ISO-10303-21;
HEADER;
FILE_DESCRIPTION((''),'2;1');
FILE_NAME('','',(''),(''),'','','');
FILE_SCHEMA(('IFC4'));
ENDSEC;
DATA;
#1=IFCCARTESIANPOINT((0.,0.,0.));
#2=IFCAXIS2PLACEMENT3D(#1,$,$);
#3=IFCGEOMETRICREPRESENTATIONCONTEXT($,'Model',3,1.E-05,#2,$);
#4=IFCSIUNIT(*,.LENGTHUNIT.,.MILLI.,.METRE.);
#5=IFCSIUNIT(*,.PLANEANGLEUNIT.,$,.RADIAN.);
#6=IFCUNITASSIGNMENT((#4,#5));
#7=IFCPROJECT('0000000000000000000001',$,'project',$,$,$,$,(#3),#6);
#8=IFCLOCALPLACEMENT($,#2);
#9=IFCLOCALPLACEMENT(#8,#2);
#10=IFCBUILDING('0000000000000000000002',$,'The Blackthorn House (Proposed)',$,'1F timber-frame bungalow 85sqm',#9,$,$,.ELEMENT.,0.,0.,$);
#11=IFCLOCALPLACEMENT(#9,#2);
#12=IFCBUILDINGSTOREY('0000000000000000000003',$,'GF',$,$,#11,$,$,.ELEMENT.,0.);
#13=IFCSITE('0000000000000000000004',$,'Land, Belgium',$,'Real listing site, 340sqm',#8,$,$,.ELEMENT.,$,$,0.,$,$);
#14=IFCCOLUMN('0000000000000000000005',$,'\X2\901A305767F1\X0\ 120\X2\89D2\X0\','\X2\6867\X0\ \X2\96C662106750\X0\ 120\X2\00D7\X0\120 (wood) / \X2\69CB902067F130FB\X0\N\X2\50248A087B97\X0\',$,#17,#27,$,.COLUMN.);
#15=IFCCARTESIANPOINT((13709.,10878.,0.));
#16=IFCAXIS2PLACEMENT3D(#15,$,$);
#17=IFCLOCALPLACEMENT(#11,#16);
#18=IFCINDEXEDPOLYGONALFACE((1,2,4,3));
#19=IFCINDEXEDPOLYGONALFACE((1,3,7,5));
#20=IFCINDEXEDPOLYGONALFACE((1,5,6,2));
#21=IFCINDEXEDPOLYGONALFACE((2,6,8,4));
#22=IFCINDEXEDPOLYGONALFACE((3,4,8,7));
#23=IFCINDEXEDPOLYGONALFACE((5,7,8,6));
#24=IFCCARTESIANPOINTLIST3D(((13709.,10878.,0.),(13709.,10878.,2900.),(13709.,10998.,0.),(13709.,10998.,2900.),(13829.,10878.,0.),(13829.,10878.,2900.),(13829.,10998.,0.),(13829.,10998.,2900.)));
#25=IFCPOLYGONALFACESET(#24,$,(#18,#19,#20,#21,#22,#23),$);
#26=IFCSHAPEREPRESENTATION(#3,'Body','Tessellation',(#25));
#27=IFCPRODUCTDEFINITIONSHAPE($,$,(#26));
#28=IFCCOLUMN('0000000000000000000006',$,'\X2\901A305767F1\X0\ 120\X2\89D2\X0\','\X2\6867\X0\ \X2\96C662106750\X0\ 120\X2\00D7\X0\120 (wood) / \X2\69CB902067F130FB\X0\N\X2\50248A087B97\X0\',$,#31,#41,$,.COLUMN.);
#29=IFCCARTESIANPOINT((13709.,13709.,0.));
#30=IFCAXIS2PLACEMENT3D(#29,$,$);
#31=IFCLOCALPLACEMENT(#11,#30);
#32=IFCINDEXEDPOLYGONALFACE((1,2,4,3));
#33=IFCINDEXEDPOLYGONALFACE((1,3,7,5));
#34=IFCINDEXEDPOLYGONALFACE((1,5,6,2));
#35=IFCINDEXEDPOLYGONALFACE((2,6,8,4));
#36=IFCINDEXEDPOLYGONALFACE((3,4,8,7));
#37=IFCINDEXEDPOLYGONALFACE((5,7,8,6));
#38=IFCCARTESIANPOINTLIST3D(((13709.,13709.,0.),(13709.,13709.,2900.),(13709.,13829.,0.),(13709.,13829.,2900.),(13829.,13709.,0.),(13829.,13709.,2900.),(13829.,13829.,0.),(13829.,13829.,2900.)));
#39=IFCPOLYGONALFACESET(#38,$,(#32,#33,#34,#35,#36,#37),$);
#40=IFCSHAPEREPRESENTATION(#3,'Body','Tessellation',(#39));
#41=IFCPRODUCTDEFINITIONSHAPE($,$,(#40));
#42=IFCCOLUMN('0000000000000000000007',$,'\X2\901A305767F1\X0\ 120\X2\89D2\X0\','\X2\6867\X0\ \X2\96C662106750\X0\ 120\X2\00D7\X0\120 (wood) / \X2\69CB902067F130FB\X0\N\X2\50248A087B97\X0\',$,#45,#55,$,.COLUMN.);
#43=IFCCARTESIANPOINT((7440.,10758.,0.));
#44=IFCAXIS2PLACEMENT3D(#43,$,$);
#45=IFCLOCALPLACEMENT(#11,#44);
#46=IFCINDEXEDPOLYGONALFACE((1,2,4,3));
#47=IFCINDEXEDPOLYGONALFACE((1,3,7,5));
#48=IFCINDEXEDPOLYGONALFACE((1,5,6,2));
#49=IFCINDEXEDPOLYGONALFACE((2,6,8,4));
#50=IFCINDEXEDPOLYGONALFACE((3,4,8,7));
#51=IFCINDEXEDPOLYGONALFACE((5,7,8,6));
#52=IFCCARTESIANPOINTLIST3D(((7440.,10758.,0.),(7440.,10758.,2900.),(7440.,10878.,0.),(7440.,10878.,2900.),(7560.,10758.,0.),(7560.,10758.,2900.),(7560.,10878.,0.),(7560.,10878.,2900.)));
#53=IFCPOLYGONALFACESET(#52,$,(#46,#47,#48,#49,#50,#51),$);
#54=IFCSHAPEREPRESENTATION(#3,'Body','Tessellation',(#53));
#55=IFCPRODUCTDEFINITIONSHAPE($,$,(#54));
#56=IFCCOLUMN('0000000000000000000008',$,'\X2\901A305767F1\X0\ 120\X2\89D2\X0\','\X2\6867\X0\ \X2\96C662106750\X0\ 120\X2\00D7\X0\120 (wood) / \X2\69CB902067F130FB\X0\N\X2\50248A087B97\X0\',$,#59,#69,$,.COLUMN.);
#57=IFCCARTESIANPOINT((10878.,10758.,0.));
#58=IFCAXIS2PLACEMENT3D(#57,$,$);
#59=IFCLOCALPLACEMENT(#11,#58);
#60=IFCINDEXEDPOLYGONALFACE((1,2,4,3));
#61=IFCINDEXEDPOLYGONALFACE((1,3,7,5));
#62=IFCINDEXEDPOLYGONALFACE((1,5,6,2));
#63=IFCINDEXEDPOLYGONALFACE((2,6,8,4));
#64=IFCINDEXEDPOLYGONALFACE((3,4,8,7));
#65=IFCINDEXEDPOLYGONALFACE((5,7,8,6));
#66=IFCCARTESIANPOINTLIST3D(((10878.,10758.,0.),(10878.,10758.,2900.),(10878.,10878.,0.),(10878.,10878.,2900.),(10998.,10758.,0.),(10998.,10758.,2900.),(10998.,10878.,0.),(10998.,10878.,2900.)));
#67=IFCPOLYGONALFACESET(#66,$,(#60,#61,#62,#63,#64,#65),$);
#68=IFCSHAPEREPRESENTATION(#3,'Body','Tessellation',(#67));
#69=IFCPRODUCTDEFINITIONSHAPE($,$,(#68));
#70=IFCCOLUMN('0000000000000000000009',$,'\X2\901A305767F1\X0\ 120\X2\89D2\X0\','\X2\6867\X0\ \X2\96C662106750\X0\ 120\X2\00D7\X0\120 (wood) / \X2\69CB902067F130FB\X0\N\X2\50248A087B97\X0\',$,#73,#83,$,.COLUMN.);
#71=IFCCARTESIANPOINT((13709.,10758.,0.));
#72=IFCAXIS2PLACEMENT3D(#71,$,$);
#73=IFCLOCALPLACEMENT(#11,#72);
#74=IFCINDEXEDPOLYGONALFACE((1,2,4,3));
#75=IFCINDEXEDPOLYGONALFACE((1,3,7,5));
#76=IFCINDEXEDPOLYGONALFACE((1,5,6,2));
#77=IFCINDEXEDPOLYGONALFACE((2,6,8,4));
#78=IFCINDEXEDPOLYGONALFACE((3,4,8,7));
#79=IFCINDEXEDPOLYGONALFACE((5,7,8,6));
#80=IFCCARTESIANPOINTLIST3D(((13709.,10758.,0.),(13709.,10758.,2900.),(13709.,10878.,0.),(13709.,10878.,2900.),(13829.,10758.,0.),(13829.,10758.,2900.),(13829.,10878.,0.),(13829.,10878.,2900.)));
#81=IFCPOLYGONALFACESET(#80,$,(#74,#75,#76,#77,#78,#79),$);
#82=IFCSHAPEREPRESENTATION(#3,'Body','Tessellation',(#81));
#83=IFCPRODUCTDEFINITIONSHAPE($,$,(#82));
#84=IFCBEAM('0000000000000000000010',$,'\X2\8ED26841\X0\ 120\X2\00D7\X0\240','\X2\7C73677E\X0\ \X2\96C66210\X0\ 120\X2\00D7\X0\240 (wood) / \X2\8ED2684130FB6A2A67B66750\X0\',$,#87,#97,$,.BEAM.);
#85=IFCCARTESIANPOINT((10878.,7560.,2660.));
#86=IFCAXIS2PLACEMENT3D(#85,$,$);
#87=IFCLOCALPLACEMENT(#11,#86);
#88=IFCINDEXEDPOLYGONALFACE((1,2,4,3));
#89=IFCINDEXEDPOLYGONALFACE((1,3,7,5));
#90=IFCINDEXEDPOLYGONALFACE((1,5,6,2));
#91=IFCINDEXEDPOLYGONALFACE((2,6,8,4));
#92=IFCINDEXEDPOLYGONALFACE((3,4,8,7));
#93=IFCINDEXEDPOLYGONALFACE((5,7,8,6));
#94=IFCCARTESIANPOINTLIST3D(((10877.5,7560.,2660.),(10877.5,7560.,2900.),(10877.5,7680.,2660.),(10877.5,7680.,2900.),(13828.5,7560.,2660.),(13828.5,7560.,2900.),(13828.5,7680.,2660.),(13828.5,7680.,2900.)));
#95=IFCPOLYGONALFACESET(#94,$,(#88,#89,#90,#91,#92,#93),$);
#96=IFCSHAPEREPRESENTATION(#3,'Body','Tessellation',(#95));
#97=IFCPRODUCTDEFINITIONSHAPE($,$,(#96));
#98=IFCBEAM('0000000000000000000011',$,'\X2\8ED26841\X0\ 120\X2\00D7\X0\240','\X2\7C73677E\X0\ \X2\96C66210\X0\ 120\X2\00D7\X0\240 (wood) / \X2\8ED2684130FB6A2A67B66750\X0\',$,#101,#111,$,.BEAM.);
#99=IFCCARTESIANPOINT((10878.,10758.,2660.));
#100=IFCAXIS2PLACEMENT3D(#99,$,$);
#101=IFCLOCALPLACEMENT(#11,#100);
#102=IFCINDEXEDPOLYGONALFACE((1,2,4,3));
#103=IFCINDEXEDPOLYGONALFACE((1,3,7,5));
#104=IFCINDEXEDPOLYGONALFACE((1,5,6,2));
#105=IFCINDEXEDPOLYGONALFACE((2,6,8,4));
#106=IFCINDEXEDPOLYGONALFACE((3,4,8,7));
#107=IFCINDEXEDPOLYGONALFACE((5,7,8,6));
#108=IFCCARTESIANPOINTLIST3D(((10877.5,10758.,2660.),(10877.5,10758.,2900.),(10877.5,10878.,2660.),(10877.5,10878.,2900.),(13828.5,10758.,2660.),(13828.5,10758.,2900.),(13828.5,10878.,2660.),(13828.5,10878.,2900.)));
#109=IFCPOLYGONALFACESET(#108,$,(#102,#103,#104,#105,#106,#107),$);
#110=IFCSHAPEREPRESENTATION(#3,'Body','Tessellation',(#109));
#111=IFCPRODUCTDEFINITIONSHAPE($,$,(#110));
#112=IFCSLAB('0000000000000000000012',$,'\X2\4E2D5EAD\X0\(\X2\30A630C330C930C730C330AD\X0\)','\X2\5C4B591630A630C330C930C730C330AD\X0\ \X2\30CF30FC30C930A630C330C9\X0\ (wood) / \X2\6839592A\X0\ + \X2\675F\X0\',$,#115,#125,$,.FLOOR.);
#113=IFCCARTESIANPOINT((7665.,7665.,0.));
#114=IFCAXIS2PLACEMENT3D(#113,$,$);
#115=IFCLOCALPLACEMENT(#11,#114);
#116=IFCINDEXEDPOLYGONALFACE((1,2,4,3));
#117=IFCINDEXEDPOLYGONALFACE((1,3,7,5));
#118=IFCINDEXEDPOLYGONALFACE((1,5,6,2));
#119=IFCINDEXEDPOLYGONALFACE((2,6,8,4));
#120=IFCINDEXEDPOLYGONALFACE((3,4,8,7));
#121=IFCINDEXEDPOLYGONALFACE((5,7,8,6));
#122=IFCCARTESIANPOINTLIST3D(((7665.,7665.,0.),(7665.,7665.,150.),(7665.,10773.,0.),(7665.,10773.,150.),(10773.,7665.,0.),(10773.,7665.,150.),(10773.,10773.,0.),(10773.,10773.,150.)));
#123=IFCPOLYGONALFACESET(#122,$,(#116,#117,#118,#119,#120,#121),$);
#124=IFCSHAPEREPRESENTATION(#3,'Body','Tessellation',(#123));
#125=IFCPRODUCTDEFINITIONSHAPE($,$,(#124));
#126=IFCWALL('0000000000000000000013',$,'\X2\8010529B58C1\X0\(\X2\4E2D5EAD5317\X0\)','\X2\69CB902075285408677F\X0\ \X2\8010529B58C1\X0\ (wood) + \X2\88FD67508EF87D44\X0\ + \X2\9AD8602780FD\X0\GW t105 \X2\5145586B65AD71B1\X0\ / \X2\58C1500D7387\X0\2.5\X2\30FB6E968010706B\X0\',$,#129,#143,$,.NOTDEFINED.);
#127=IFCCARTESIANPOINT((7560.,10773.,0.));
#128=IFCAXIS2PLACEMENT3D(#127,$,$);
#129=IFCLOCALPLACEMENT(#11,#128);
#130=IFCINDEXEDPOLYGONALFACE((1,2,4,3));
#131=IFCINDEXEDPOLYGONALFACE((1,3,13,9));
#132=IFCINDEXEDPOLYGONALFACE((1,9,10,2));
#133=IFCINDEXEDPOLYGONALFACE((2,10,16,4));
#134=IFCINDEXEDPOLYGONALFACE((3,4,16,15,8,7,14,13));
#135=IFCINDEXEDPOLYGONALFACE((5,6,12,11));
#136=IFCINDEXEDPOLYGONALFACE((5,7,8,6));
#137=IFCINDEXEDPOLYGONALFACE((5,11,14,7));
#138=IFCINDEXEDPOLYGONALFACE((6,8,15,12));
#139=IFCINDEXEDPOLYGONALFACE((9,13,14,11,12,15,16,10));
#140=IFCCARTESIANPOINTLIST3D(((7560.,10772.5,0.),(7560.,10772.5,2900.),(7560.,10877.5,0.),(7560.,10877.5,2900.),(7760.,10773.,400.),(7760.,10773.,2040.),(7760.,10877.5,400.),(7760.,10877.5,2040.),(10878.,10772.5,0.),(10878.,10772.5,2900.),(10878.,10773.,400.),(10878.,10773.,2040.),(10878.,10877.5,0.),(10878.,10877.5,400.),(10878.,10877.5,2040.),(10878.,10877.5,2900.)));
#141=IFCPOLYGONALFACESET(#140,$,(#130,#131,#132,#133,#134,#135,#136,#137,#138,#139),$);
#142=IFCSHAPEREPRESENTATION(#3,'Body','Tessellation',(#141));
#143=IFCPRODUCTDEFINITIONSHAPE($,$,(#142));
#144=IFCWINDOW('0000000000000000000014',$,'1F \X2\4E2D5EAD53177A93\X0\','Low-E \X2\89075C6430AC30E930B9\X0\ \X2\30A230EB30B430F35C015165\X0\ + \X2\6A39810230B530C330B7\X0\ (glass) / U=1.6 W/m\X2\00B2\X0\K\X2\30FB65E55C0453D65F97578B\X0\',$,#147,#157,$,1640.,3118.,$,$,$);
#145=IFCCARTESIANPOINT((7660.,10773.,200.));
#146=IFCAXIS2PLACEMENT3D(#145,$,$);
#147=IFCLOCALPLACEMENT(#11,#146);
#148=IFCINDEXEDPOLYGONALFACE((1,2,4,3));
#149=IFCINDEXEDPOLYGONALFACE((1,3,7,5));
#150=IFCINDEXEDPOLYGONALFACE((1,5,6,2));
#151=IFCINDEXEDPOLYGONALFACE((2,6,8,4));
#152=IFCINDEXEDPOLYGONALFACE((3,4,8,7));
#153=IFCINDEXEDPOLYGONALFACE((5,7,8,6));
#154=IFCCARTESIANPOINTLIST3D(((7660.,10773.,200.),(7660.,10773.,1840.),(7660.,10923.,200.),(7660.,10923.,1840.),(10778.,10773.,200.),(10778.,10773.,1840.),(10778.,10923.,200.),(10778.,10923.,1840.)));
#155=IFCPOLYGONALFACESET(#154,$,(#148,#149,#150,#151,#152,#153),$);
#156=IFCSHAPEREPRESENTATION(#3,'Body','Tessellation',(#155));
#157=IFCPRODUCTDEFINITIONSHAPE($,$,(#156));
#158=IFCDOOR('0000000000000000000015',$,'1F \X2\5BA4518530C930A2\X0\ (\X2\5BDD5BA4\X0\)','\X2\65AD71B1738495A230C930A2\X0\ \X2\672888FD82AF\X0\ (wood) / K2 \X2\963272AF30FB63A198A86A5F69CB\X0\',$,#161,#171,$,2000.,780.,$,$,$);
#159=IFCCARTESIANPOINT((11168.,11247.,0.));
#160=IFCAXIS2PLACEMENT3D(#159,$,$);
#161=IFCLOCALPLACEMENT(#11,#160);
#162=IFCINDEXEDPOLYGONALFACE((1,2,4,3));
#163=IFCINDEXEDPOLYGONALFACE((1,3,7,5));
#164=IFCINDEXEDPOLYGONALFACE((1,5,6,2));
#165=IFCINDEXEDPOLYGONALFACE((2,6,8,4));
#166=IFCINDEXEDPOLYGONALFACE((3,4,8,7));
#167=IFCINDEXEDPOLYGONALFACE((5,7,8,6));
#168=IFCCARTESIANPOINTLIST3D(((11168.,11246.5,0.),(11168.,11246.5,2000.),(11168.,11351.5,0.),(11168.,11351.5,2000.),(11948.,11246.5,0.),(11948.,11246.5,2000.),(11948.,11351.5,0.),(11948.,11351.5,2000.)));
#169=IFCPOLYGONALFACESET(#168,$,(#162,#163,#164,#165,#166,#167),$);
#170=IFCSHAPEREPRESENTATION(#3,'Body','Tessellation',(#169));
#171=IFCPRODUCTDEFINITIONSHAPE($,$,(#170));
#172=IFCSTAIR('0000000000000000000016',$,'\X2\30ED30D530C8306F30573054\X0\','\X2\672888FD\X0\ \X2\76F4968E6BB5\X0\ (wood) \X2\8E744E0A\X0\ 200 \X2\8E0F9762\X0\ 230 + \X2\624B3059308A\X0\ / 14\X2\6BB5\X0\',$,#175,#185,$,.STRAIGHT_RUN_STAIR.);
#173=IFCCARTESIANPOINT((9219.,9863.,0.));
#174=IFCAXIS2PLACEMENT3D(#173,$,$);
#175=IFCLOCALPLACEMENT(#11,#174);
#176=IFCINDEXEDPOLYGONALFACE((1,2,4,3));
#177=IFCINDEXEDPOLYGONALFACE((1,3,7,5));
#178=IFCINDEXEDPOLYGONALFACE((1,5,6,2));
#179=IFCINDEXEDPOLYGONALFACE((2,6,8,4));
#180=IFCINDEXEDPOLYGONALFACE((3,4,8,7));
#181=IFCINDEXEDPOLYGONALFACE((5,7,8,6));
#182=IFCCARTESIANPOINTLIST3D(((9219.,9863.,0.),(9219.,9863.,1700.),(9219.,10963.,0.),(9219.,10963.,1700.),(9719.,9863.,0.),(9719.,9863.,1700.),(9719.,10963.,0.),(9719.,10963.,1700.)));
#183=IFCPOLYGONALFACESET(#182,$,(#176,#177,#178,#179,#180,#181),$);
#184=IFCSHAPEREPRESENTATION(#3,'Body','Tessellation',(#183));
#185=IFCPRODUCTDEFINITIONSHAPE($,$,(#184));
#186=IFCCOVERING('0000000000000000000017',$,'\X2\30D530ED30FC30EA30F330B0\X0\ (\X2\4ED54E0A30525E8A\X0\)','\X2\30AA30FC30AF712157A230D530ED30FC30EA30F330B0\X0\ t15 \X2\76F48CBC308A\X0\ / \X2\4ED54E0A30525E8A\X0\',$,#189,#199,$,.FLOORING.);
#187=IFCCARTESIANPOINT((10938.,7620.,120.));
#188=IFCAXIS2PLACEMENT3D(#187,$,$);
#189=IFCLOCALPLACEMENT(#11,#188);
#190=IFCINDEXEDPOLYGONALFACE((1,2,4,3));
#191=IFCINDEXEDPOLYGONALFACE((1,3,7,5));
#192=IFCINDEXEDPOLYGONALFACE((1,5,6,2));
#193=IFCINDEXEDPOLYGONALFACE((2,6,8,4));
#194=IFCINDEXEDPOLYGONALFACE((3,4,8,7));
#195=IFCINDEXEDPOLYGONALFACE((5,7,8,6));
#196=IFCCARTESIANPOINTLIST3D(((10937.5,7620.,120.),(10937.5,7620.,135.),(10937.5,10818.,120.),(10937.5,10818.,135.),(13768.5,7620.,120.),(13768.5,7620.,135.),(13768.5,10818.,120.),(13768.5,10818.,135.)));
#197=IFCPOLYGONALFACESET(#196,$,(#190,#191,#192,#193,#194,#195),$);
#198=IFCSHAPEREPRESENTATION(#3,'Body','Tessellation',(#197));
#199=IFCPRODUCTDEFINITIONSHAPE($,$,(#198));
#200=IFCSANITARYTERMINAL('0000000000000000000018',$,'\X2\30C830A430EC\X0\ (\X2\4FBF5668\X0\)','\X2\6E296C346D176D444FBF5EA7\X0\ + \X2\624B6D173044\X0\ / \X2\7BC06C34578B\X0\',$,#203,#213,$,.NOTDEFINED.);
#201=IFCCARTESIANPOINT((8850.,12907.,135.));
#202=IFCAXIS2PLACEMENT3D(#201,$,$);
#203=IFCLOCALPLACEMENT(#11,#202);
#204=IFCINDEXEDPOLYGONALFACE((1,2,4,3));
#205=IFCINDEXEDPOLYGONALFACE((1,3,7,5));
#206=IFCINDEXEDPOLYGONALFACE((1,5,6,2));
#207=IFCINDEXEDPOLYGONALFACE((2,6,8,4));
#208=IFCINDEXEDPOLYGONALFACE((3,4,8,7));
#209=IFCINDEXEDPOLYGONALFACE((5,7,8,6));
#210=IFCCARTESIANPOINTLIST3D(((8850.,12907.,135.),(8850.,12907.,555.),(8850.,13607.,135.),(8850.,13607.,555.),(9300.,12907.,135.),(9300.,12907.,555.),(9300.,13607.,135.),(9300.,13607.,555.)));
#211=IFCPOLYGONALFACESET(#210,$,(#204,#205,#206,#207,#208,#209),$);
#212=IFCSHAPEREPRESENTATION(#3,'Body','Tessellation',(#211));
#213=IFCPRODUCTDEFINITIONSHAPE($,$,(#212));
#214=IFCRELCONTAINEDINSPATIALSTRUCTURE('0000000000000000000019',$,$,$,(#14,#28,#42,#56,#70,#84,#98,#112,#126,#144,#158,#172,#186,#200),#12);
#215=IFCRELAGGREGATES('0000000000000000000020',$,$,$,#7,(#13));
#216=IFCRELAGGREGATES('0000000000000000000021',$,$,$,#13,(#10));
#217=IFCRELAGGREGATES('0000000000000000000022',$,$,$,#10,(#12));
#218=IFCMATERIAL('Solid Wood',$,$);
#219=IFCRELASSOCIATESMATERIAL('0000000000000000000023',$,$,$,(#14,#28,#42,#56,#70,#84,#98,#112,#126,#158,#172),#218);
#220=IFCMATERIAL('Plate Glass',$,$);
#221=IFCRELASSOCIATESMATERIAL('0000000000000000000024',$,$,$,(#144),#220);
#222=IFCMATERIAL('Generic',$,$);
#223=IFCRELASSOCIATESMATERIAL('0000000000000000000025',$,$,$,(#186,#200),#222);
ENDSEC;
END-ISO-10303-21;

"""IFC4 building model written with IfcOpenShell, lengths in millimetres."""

from ifc_helpers import new_model, si_unit, frame, frame_2d, origin, place, context, project, spatial, rectangle, extrude, material, element, fill, save


model = new_model("IFC4")

# Units and contexts
model_context = context("Model", 3, precision=1e-05, world=origin())
ifc_project = project(units=[si_unit("LENGTHUNIT", "METRE", prefix="MILLI"), si_unit("PLANEANGLEUNIT", "RADIAN")], contexts=[model_context])

# Site, building, storey
site_placement = place(None, origin())
site = spatial("IfcSite", under=ifc_project, at=site_placement, Name="Land, Belgium", ObjectType="Real listing site, 340sqm", CompositionType="ELEMENT", RefElevation=0.0)
building_placement = place(site_placement, origin())
building = spatial("IfcBuilding", under=site, at=building_placement, Name="The Blackthorn House (Proposed)", ObjectType="1F timber-frame bungalow 85sqm", CompositionType="ELEMENT", ElevationOfRefHeight=0.0, ElevationOfTerrain=0.0)
storey_placement = place(building_placement, origin())
storey = spatial("IfcBuildingStorey", under=building, at=storey_placement, Name="GF", CompositionType="ELEMENT", Elevation=0.0)

# Columns
ifc_material_1 = material(Name="Solid Wood")
column_1_placement = place(storey_placement, frame((13709.0, 10878.0, 0.0)))
element("IfcColumn", 1, at=column_1_placement, inside=storey, material=ifc_material_1, Name="通し柱 120角", Description="桧 集成材 120×120 (wood) / 構造柱・N値計算", PredefinedType="COLUMN", context=model_context, shape_type="SweptSolid", body=[
    extrude(rectangle(XDim=120.0, YDim=120.0, at=frame_2d((60.0, 60.0))), frame((13709.0, 10878.0, 0.0)), (0.0, 0.0, 1.0), 2900.0),
])
column_2_placement = place(storey_placement, frame((13709.0, 13709.0, 0.0)))
element("IfcColumn", 2, at=column_2_placement, inside=storey, material=ifc_material_1, Name="通し柱 120角", Description="桧 集成材 120×120 (wood) / 構造柱・N値計算", PredefinedType="COLUMN", context=model_context, shape_type="SweptSolid", body=[
    extrude(rectangle(XDim=120.0, YDim=120.0, at=frame_2d((60.0, 60.0))), frame((13709.0, 13709.0, 0.0)), (0.0, 0.0, 1.0), 2900.0),
])
column_3_placement = place(storey_placement, frame((7440.0, 10758.0, 0.0)))
element("IfcColumn", 3, at=column_3_placement, inside=storey, material=ifc_material_1, Name="通し柱 120角", Description="桧 集成材 120×120 (wood) / 構造柱・N値計算", PredefinedType="COLUMN", context=model_context, shape_type="SweptSolid", body=[
    extrude(rectangle(XDim=120.0, YDim=120.0, at=frame_2d((60.0, 60.0))), frame((7440.0, 10758.0, 0.0)), (0.0, 0.0, 1.0), 2900.0),
])
column_4_placement = place(storey_placement, frame((10878.0, 10758.0, 0.0)))
element("IfcColumn", 4, at=column_4_placement, inside=storey, material=ifc_material_1, Name="通し柱 120角", Description="桧 集成材 120×120 (wood) / 構造柱・N値計算", PredefinedType="COLUMN", context=model_context, shape_type="SweptSolid", body=[
    extrude(rectangle(XDim=120.0, YDim=120.0, at=frame_2d((60.0, 60.0))), frame((10878.0, 10758.0, 0.0)), (0.0, 0.0, 1.0), 2900.0),
])
column_5_placement = place(storey_placement, frame((13709.0, 10758.0, 0.0)))
element("IfcColumn", 5, at=column_5_placement, inside=storey, material=ifc_material_1, Name="通し柱 120角", Description="桧 集成材 120×120 (wood) / 構造柱・N値計算", PredefinedType="COLUMN", context=model_context, shape_type="SweptSolid", body=[
    extrude(rectangle(XDim=120.0, YDim=120.0, at=frame_2d((60.0, 60.0))), frame((13709.0, 10758.0, 0.0)), (0.0, 0.0, 1.0), 2900.0),
])

# Beams
beam_1_placement = place(storey_placement, frame((10878.0, 7560.0, 2660.0)))
element("IfcBeam", 6, at=beam_1_placement, inside=storey, material=ifc_material_1, Name="軒桁 120×240", Description="米松 集成 120×240 (wood) / 軒桁・横架材", PredefinedType="BEAM", context=model_context, shape_type="SweptSolid", body=[
    extrude(rectangle(XDim=2951.0, YDim=120.0, at=frame_2d((1475.0, 60.0))), frame((10878.0, 7560.0, 2660.0)), (0.0, 0.0, 1.0), 240.0),
])
beam_2_placement = place(storey_placement, frame((10878.0, 10758.0, 2660.0)))
element("IfcBeam", 7, at=beam_2_placement, inside=storey, material=ifc_material_1, Name="軒桁 120×240", Description="米松 集成 120×240 (wood) / 軒桁・横架材", PredefinedType="BEAM", context=model_context, shape_type="SweptSolid", body=[
    extrude(rectangle(XDim=2951.0, YDim=120.0, at=frame_2d((1475.0, 60.0))), frame((10878.0, 10758.0, 2660.0)), (0.0, 0.0, 1.0), 240.0),
])

# Slab
slab_placement = place(storey_placement, frame((7665.0, 7665.0, 0.0)))
element("IfcSlab", 8, at=slab_placement, inside=storey, material=ifc_material_1, Name="中庭(ウッドデッキ)", Description="屋外ウッドデッキ ハードウッド (wood) / 根太 + 束", PredefinedType="FLOOR", context=model_context, shape_type="SweptSolid", body=[
    extrude(rectangle(XDim=3108.0, YDim=3108.0, at=frame_2d((1554.0, 1554.0))), frame((7665.0, 7665.0, 0.0)), (0.0, 0.0, 1.0), 150.0),
])

# Wall, opening, window
wall_1_placement = place(storey_placement, frame((7560.0, 10773.0, 0.0)))
wall_1 = element("IfcWall", 9, at=wall_1_placement, inside=storey, material=ifc_material_1, Name="耐力壁(中庭北)", Description="構造用合板 耐力壁 (wood) + 製材軸組 + 高性能GW t105 充填断熱 / 壁倍率2.5・準耐火", PredefinedType="NOTDEFINED", context=model_context, shape_type="SweptSolid", body=[
    extrude(rectangle(XDim=3318.0, YDim=105.0, at=frame_2d((1659.0, 52.0))), frame((7560.0, 10773.0, 0.0)), (0.0, 0.0, 1.0), 2900.0),
])
opening_placement = place(storey_placement, frame((7660.0, 10773.0, 200.0)))
opening = element("IfcOpeningElement", 10, at=opening_placement, cuts=wall_1, PredefinedType="NOTDEFINED", context=model_context, shape_type="SweptSolid", body=[
    extrude(rectangle(XDim=3118.0, YDim=150.0, at=frame_2d((1559.0, 75.0))), frame((7660.0, 10773.0, 200.0)), (0.0, 0.0, 1.0), 1640.0),
])
ifc_material_2 = material(Name="Plate Glass")
window_placement = place(storey_placement, frame((7660.0, 10773.0, 200.0)))
window = element("IfcWindow", 11, at=window_placement, inside=storey, material=ifc_material_2, Name="1F 中庭北窓", Description="Low-E 複層ガラス アルゴン封入 + 樹脂サッシ (glass) / U=1.6 W/m²K・日射取得型", OverallHeight=1640.0, OverallWidth=3118.0, context=model_context, shape_type="SweptSolid", body=[
    extrude(rectangle(XDim=3118.0, YDim=150.0, at=frame_2d((1559.0, 75.0))), frame((7660.0, 10773.0, 200.0)), (0.0, 0.0, 1.0), 1640.0),
])
fill(opening, window)

# Door
door_placement = place(storey_placement, frame((11168.0, 11247.0, 0.0)))
element("IfcDoor", 12, at=door_placement, inside=storey, material=ifc_material_1, Name="1F 室内ドア (寝室)", Description="断熱玄関ドア 木製芯 (wood) / K2 防犯・採風機構", OverallHeight=2000.0, OverallWidth=780.0, context=model_context, shape_type="SweptSolid", body=[
    extrude(rectangle(XDim=780.0, YDim=105.0, at=frame_2d((390.0, 52.0))), frame((11168.0, 11247.0, 0.0)), (0.0, 0.0, 1.0), 2000.0),
])

# Stair
stair_placement = place(storey_placement, frame((9219.0, 9863.0, 0.0)))
element("IfcStair", 13, at=stair_placement, inside=storey, material=ifc_material_1, Name="ロフトはしご", Description="木製 直階段 (wood) 蹴上 200 踏面 230 + 手すり / 14段", PredefinedType="STRAIGHT_RUN_STAIR", context=model_context, shape_type="SweptSolid", body=[
    extrude(rectangle(XDim=500.0, YDim=1100.0, at=frame_2d((250.0, 550.0))), frame((9219.0, 9863.0, 0.0)), (0.0, 0.0, 1.0), 1700.0),
])

# Covering
ifc_material_3 = material(Name="Generic")
covering_placement = place(storey_placement, frame((10938.0, 7620.0, 120.0)))
element("IfcCovering", 14, at=covering_placement, inside=storey, material=ifc_material_3, Name="フローリング (仕上げ床)", Description="オーク無垢フローリング t15 直貼り / 仕上げ床", PredefinedType="FLOORING", context=model_context, shape_type="SweptSolid", body=[
    extrude(rectangle(XDim=2831.0, YDim=3198.0, at=frame_2d((1415.0, 1599.0))), frame((10938.0, 7620.0, 120.0)), (0.0, 0.0, 1.0), 15.0),
])

# Sanitary terminal
sanitary_terminal_placement = place(storey_placement, frame((8850.0, 12907.0, 135.0)))
element("IfcSanitaryTerminal", 15, at=sanitary_terminal_placement, inside=storey, material=ifc_material_3, Name="トイレ (便器)", Description="温水洗浄便座 + 手洗い / 節水型", PredefinedType="NOTDEFINED", context=model_context, shape_type="SweptSolid", body=[
    extrude(rectangle(XDim=450.0, YDim=700.0, at=frame_2d((225.0, 350.0))), frame((8850.0, 12907.0, 135.0)), (0.0, 0.0, 1.0), 420.0),
])

save(model, "model.ifc")
